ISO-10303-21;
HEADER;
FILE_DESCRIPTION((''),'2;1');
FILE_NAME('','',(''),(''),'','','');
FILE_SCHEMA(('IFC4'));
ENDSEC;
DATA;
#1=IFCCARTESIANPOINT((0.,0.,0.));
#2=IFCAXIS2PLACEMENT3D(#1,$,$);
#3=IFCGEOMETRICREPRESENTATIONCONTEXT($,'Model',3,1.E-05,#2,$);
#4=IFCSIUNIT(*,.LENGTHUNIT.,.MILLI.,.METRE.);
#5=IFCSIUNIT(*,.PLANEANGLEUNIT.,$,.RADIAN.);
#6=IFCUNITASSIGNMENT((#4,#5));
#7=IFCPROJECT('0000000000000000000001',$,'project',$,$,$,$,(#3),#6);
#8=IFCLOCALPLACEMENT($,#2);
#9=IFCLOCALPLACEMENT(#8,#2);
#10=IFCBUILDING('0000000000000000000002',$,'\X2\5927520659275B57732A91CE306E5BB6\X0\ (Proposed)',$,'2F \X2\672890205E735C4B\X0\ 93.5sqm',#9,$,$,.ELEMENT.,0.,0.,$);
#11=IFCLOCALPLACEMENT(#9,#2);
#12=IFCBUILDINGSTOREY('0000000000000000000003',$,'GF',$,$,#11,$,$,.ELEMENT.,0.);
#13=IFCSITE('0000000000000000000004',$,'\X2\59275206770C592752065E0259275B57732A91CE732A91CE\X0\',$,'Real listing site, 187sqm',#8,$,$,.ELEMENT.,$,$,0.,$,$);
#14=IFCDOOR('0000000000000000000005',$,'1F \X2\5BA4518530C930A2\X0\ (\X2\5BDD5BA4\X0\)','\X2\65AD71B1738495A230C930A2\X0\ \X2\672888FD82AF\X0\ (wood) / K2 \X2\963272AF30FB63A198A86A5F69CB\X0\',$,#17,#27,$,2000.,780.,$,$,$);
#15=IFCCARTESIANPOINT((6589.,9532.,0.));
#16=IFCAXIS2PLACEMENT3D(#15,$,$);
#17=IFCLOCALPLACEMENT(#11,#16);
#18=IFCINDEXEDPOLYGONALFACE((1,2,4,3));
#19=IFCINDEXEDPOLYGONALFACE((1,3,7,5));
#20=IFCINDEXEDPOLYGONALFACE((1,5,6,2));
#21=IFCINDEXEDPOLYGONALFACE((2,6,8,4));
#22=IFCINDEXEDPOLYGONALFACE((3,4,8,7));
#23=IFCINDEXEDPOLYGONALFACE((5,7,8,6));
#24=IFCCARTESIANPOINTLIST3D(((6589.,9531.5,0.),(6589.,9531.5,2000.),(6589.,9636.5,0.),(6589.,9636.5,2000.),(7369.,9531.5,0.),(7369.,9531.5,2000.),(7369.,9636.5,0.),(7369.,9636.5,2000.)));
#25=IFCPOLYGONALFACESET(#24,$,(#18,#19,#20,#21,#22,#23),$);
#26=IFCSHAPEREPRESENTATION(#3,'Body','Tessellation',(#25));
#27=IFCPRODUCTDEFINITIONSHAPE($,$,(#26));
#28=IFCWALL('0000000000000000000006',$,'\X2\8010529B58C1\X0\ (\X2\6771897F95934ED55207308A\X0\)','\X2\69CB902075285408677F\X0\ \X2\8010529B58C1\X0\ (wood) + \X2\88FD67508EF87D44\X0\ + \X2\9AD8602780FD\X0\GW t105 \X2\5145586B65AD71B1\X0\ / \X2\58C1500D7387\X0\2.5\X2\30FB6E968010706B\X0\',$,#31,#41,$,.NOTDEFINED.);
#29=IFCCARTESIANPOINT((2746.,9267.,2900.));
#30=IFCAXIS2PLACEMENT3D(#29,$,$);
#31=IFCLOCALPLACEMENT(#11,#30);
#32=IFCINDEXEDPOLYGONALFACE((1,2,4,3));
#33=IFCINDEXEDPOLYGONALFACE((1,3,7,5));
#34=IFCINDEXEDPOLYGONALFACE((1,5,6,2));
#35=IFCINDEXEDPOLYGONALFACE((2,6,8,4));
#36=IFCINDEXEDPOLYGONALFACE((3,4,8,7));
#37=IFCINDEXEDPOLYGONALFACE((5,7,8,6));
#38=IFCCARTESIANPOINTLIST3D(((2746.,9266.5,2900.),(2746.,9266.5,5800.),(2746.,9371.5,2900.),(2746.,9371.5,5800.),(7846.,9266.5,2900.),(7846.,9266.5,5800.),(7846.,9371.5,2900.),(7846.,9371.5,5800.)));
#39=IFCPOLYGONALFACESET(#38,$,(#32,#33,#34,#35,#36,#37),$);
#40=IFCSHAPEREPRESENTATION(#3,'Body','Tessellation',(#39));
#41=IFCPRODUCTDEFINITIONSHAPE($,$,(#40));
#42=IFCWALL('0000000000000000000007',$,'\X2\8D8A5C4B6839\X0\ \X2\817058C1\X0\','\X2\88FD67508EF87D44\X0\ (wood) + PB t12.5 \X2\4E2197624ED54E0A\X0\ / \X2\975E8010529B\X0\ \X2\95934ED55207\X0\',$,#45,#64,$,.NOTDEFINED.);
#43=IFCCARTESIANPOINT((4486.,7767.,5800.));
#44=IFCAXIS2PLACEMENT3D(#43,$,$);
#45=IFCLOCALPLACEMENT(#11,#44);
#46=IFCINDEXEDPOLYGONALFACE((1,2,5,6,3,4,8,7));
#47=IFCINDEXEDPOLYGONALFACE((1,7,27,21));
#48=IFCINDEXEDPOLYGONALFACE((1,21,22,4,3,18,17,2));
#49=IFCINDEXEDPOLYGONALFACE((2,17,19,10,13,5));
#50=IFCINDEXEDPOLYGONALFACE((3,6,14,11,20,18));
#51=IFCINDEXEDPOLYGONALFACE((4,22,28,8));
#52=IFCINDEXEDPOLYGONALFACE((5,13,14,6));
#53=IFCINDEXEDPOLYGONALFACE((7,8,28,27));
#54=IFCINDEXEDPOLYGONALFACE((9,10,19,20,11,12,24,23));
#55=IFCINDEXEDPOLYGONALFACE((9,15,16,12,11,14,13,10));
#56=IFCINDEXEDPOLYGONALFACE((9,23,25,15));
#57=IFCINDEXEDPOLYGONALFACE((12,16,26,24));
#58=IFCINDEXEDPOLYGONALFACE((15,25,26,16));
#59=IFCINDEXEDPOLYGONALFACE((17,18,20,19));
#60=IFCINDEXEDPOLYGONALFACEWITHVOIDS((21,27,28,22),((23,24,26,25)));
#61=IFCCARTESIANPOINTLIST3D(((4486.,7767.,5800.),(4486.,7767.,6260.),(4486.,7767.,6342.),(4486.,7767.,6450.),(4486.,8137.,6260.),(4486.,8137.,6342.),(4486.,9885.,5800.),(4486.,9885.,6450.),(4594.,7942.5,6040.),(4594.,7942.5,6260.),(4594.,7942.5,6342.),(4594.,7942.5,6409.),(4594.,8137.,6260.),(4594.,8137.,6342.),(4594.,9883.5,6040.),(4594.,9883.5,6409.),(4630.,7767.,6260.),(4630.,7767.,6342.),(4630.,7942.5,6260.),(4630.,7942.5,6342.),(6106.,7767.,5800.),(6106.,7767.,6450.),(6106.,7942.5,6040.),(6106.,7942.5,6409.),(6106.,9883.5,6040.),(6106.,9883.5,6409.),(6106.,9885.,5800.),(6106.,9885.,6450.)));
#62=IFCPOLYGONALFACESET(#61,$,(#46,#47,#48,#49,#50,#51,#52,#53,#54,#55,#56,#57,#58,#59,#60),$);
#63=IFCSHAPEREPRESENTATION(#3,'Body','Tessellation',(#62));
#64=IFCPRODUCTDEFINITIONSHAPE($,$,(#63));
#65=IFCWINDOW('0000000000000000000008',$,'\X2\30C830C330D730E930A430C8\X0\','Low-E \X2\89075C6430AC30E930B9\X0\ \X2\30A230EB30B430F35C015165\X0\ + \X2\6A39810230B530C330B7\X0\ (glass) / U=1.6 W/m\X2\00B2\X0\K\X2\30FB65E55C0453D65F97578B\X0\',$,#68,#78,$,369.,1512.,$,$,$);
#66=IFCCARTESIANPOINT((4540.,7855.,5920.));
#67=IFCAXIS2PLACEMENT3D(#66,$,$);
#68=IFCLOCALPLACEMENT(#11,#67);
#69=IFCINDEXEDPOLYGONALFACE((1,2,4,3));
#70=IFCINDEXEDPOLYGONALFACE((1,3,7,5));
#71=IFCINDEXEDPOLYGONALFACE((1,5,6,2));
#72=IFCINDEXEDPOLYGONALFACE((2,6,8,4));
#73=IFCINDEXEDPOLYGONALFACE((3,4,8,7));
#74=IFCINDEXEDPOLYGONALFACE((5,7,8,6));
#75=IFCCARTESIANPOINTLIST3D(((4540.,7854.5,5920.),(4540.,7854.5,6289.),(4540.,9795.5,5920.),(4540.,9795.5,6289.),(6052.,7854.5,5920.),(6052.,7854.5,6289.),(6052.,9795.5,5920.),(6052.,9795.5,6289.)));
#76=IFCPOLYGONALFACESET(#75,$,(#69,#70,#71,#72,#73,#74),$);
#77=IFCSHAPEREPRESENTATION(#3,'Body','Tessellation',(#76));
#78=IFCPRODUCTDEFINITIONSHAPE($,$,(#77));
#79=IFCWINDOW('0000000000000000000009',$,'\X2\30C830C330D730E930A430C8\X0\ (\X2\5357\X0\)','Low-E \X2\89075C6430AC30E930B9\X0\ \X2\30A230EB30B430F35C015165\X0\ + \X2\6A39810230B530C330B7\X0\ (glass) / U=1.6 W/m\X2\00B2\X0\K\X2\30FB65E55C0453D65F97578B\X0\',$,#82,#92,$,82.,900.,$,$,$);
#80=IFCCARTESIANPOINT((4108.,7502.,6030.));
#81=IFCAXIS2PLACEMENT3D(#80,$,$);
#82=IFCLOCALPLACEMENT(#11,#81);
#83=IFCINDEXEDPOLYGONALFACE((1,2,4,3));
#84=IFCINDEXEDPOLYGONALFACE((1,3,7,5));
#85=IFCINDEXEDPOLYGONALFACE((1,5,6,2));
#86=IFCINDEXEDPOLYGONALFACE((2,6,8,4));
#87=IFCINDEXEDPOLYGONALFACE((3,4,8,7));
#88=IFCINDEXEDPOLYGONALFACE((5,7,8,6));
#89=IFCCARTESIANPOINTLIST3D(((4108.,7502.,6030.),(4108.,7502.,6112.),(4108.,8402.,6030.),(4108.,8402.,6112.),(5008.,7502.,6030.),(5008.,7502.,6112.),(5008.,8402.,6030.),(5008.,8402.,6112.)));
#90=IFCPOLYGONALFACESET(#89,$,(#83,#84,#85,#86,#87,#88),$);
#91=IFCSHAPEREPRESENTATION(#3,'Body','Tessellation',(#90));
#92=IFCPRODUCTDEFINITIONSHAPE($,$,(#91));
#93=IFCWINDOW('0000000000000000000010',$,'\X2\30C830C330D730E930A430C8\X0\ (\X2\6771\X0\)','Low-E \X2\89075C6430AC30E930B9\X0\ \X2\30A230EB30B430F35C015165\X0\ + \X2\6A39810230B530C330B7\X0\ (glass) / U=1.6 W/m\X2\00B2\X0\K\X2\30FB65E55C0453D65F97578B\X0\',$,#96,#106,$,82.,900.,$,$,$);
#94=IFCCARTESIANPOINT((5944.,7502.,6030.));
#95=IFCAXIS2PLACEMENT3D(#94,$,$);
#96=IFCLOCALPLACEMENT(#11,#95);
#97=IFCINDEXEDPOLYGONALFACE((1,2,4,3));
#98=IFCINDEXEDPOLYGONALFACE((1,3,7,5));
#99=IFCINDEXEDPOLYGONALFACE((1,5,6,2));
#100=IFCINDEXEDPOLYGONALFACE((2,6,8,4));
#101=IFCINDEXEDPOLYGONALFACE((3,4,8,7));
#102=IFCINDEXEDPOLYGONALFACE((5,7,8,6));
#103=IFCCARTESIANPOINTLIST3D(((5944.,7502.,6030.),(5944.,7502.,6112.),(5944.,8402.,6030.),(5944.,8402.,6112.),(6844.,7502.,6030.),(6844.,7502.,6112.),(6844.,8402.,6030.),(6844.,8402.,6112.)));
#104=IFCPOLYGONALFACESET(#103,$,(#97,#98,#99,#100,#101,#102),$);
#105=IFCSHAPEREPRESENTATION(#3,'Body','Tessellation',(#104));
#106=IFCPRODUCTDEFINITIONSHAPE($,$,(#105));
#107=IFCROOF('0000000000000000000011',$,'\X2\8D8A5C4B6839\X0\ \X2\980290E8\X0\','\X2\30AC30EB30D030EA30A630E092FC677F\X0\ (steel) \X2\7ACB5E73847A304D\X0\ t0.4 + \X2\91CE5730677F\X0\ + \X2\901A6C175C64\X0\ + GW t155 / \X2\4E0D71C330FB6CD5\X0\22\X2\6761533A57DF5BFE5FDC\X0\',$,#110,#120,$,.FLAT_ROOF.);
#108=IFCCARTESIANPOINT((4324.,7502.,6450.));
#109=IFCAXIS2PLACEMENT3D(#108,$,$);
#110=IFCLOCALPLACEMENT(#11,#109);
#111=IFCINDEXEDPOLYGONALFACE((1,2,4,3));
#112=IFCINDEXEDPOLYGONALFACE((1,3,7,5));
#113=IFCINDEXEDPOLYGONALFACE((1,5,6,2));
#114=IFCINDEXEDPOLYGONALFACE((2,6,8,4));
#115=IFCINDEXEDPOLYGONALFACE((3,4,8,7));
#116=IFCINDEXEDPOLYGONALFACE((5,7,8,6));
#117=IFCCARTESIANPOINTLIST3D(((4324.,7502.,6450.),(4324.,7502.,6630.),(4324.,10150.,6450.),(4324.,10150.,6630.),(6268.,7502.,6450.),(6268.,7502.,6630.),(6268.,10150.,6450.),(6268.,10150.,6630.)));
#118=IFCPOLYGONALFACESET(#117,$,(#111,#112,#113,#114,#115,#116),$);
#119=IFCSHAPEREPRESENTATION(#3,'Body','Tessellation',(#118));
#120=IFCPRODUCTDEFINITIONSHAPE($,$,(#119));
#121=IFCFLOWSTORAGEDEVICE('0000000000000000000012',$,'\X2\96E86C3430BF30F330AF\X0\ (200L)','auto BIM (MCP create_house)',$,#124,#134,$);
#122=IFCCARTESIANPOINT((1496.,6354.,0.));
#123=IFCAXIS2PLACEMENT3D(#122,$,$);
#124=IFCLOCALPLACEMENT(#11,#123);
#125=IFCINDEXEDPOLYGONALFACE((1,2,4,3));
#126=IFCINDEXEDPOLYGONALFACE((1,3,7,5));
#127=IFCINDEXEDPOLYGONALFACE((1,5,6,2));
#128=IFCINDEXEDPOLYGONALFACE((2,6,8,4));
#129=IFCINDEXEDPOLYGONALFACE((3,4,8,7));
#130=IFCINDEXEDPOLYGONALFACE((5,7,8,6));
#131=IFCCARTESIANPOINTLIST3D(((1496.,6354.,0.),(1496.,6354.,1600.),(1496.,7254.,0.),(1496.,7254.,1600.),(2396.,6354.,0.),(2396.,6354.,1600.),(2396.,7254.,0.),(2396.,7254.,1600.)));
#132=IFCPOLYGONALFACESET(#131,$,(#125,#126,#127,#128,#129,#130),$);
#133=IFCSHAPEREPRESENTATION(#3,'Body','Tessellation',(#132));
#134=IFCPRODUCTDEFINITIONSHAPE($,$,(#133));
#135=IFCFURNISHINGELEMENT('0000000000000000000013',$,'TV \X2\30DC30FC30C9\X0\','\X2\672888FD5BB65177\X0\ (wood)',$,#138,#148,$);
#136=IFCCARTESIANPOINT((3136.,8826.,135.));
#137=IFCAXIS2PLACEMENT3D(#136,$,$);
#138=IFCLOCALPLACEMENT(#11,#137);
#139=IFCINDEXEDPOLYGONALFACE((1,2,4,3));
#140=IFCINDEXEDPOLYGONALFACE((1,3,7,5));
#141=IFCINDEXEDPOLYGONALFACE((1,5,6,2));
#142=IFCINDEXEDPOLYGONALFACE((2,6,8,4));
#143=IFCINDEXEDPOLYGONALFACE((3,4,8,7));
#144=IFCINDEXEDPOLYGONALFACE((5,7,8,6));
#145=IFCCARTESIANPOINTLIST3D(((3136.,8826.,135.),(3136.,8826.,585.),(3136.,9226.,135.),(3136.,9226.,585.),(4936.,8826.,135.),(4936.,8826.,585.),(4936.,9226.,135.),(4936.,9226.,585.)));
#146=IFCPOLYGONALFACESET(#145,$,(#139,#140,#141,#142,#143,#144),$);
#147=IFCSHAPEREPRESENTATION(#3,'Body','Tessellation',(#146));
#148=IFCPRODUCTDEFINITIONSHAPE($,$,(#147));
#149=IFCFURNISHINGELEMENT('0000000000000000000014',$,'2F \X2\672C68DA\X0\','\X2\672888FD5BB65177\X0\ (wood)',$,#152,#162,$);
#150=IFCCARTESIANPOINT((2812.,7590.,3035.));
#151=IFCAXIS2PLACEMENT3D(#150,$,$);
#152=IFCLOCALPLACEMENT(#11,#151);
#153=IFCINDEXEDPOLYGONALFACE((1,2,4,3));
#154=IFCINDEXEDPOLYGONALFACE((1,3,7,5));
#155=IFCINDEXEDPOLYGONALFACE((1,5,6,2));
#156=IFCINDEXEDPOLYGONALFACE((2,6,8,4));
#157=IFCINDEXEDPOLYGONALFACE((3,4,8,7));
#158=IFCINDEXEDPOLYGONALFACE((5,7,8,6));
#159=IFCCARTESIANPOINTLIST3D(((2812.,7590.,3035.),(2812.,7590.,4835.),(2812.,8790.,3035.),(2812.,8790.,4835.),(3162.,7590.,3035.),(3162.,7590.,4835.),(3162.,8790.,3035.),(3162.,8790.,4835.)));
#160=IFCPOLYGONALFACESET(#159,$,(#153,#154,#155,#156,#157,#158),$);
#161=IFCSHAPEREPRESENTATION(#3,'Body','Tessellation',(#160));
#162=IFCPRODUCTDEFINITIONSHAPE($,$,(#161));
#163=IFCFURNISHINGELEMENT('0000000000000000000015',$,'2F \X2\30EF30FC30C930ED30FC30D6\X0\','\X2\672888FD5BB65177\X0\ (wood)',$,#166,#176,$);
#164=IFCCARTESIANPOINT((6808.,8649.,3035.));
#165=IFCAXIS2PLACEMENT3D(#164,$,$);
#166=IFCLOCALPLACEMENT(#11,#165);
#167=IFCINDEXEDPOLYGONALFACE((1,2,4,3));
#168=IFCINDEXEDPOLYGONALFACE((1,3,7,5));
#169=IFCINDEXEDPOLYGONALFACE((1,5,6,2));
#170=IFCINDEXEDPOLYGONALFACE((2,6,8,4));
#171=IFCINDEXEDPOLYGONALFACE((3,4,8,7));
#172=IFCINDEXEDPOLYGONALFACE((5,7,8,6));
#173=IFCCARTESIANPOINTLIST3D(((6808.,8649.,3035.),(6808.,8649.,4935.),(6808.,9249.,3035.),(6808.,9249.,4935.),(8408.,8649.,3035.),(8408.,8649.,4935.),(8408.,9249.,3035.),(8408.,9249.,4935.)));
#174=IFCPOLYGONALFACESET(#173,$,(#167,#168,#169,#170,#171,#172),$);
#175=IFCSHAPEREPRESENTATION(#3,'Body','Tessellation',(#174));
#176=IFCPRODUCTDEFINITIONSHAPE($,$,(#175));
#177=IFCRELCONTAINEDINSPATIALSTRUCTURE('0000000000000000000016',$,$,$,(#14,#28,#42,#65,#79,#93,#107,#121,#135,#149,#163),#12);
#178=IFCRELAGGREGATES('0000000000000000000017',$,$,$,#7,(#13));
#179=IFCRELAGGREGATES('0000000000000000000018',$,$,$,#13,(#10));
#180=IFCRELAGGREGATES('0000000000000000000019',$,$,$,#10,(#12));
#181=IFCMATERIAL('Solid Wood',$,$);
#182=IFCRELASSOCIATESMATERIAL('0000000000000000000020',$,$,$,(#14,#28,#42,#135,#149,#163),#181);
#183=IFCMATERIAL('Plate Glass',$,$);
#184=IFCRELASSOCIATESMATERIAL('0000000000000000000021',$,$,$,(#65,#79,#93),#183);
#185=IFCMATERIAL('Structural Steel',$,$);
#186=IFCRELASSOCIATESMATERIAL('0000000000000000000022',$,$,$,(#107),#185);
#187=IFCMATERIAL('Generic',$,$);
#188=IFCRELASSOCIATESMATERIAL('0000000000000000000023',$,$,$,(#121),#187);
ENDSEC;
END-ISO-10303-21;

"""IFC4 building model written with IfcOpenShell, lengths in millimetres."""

from ifc_helpers import new_model, si_unit, frame, frame_2d, origin, place, context, project, spatial, rectangle, extrude, material, element, fill, save


model = new_model("IFC4")

# Units and contexts
model_context = context("Model", 3, precision=1e-05, world=origin())
ifc_project = project(units=[si_unit("LENGTHUNIT", "METRE", prefix="MILLI"), si_unit("PLANEANGLEUNIT", "RADIAN")], contexts=[model_context])

# Site, building, storey
site_placement = place(None, origin())
site = spatial("IfcSite", under=ifc_project, at=site_placement, Name="大分県大分市大字猪野猪野", ObjectType="Real listing site, 187sqm", CompositionType="ELEMENT", RefElevation=0.0)
building_placement = place(site_placement, origin())
building = spatial("IfcBuilding", under=site, at=building_placement, Name="大分大字猪野の家 (Proposed)", ObjectType="2F 木造平屋 93.5sqm", CompositionType="ELEMENT", ElevationOfRefHeight=0.0, ElevationOfTerrain=0.0)
storey_placement = place(building_placement, origin())
storey = spatial("IfcBuildingStorey", under=building, at=storey_placement, Name="GF", CompositionType="ELEMENT", Elevation=0.0)

# Shared definitions
ifc_material_1 = material(Name="Solid Wood")

# Door
door_placement = place(storey_placement, frame((6589.0, 9532.0, 0.0)))
element("IfcDoor", 1, at=door_placement, inside=storey, material=ifc_material_1, Name="1F 室内ドア (寝室)", Description="断熱玄関ドア 木製芯 (wood) / K2 防犯・採風機構", OverallHeight=2000.0, OverallWidth=780.0, context=model_context, shape_type="SweptSolid", body=[
    extrude(rectangle(XDim=780.0, YDim=105.0, at=frame_2d((390.0, 52.0))), frame((6589.0, 9532.0, 0.0)), (0.0, 0.0, 1.0), 2000.0),
])

# Wall
wall_1_placement = place(storey_placement, frame((2746.0, 9267.0, 2900.0)))
element("IfcWall", 2, at=wall_1_placement, inside=storey, material=ifc_material_1, Name="耐力壁 (東西間仕切り)", Description="構造用合板 耐力壁 (wood) + 製材軸組 + 高性能GW t105 充填断熱 / 壁倍率2.5・準耐火", PredefinedType="NOTDEFINED", context=model_context, shape_type="SweptSolid", body=[
    extrude(rectangle(XDim=5100.0, YDim=105.0, at=frame_2d((2550.0, 52.0))), frame((2746.0, 9267.0, 2900.0)), (0.0, 0.0, 1.0), 2900.0),
])

# Wall, openings, windows
wall_2_placement = place(storey_placement, frame((4486.0, 7767.0, 5800.0)))
wall_2 = element("IfcWall", 3, at=wall_2_placement, inside=storey, material=ifc_material_1, Name="越屋根 腰壁", Description="製材軸組 (wood) + PB t12.5 両面仕上 / 非耐力 間仕切", PredefinedType="NOTDEFINED", context=model_context, shape_type="SweptSolid", body=[
    extrude(rectangle(XDim=1620.0, YDim=2118.0, at=frame_2d((810.0, 1059.0))), frame((4486.0, 7767.0, 5800.0)), (0.0, 0.0, 1.0), 650.0),
])
opening_1_placement = place(storey_placement, frame((4540.0, 7855.0, 5920.0)))
opening_1 = element("IfcOpeningElement", 4, at=opening_1_placement, cuts=wall_2, PredefinedType="NOTDEFINED", context=model_context, shape_type="SweptSolid", body=[
    extrude(rectangle(XDim=1512.0, YDim=1941.0, at=frame_2d((756.0, 970.0))), frame((4540.0, 7855.0, 5920.0)), (0.0, 0.0, 1.0), 369.0),
])
opening_2_placement = place(storey_placement, frame((4108.0, 7502.0, 6030.0)))
opening_2 = element("IfcOpeningElement", 5, at=opening_2_placement, cuts=wall_2, PredefinedType="NOTDEFINED", context=model_context, shape_type="SweptSolid", body=[
    extrude(rectangle(XDim=900.0, YDim=900.0, at=frame_2d((450.0, 450.0))), frame((4108.0, 7502.0, 6030.0)), (0.0, 0.0, 1.0), 82.0),
])
opening_3_placement = place(storey_placement, frame((5944.0, 7502.0, 6030.0)))
opening_3 = element("IfcOpeningElement", 6, at=opening_3_placement, cuts=wall_2, PredefinedType="NOTDEFINED", context=model_context, shape_type="SweptSolid", body=[
    extrude(rectangle(XDim=900.0, YDim=900.0, at=frame_2d((450.0, 450.0))), frame((5944.0, 7502.0, 6030.0)), (0.0, 0.0, 1.0), 82.0),
])
ifc_material_2 = material(Name="Plate Glass")
window_1_placement = place(storey_placement, frame((4540.0, 7855.0, 5920.0)))
window_1 = element("IfcWindow", 7, at=window_1_placement, inside=storey, material=ifc_material_2, Name="トップライト", Description="Low-E 複層ガラス アルゴン封入 + 樹脂サッシ (glass) / U=1.6 W/m²K・日射取得型", OverallHeight=369.0, OverallWidth=1512.0, context=model_context, shape_type="SweptSolid", body=[
    extrude(rectangle(XDim=1512.0, YDim=1941.0, at=frame_2d((756.0, 970.0))), frame((4540.0, 7855.0, 5920.0)), (0.0, 0.0, 1.0), 369.0),
])
fill(opening_1, window_1)
window_2_placement = place(storey_placement, frame((4108.0, 7502.0, 6030.0)))
window_2 = element("IfcWindow", 8, at=window_2_placement, inside=storey, material=ifc_material_2, Name="トップライト (南)", Description="Low-E 複層ガラス アルゴン封入 + 樹脂サッシ (glass) / U=1.6 W/m²K・日射取得型", OverallHeight=82.0, OverallWidth=900.0, context=model_context, shape_type="SweptSolid", body=[
    extrude(rectangle(XDim=900.0, YDim=900.0, at=frame_2d((450.0, 450.0))), frame((4108.0, 7502.0, 6030.0)), (0.0, 0.0, 1.0), 82.0),
])
fill(opening_2, window_2)
window_3_placement = place(storey_placement, frame((5944.0, 7502.0, 6030.0)))
window_3 = element("IfcWindow", 9, at=window_3_placement, inside=storey, material=ifc_material_2, Name="トップライト (東)", Description="Low-E 複層ガラス アルゴン封入 + 樹脂サッシ (glass) / U=1.6 W/m²K・日射取得型", OverallHeight=82.0, OverallWidth=900.0, context=model_context, shape_type="SweptSolid", body=[
    extrude(rectangle(XDim=900.0, YDim=900.0, at=frame_2d((450.0, 450.0))), frame((5944.0, 7502.0, 6030.0)), (0.0, 0.0, 1.0), 82.0),
])
fill(opening_3, window_3)

# Roof
ifc_material_3 = material(Name="Structural Steel")
roof_placement = place(storey_placement, frame((4324.0, 7502.0, 6450.0)))
element("IfcRoof", 10, at=roof_placement, inside=storey, material=ifc_material_3, Name="越屋根 頂部", Description="ガルバリウム鋼板 (steel) 立平葺き t0.4 + 野地板 + 通気層 + GW t155 / 不燃・法22条区域対応", PredefinedType="FLAT_ROOF", context=model_context, shape_type="SweptSolid", body=[
    extrude(rectangle(XDim=1944.0, YDim=2648.0, at=frame_2d((972.0, 1324.0))), frame((4324.0, 7502.0, 6450.0)), (0.0, 0.0, 1.0), 180.0),
])

# Flow storage device
ifc_material_4 = material(Name="Generic")
flow_storage_device_placement = place(storey_placement, frame((1496.0, 6354.0, 0.0)))
element("IfcFlowStorageDevice", 11, at=flow_storage_device_placement, inside=storey, material=ifc_material_4, Name="雨水タンク (200L)", Description="auto BIM (MCP create_house)", context=model_context, shape_type="SweptSolid", body=[
    extrude(rectangle(XDim=900.0, YDim=900.0, at=frame_2d((450.0, 450.0))), frame((1496.0, 6354.0, 0.0)), (0.0, 0.0, 1.0), 1600.0),
])

# Furnishing elements
furnishing_1_placement = place(storey_placement, frame((3136.0, 8826.0, 135.0)))
element("IfcFurnishingElement", 12, at=furnishing_1_placement, inside=storey, material=ifc_material_1, Name="TV ボード", Description="木製家具 (wood)", context=model_context, shape_type="SweptSolid", body=[
    extrude(rectangle(XDim=1800.0, YDim=400.0, at=frame_2d((900.0, 200.0))), frame((3136.0, 8826.0, 135.0)), (0.0, 0.0, 1.0), 450.0),
])
furnishing_2_placement = place(storey_placement, frame((2812.0, 7590.0, 3035.0)))
element("IfcFurnishingElement", 13, at=furnishing_2_placement, inside=storey, material=ifc_material_1, Name="2F 本棚", Description="木製家具 (wood)", context=model_context, shape_type="SweptSolid", body=[
    extrude(rectangle(XDim=350.0, YDim=1200.0, at=frame_2d((175.0, 600.0))), frame((2812.0, 7590.0, 3035.0)), (0.0, 0.0, 1.0), 1800.0),
])
furnishing_3_placement = place(storey_placement, frame((6808.0, 8649.0, 3035.0)))
element("IfcFurnishingElement", 14, at=furnishing_3_placement, inside=storey, material=ifc_material_1, Name="2F ワードローブ", Description="木製家具 (wood)", context=model_context, shape_type="SweptSolid", body=[
    extrude(rectangle(XDim=1600.0, YDim=600.0, at=frame_2d((800.0, 300.0))), frame((6808.0, 8649.0, 3035.0)), (0.0, 0.0, 1.0), 1900.0),
])

save(model, "model.ifc")
